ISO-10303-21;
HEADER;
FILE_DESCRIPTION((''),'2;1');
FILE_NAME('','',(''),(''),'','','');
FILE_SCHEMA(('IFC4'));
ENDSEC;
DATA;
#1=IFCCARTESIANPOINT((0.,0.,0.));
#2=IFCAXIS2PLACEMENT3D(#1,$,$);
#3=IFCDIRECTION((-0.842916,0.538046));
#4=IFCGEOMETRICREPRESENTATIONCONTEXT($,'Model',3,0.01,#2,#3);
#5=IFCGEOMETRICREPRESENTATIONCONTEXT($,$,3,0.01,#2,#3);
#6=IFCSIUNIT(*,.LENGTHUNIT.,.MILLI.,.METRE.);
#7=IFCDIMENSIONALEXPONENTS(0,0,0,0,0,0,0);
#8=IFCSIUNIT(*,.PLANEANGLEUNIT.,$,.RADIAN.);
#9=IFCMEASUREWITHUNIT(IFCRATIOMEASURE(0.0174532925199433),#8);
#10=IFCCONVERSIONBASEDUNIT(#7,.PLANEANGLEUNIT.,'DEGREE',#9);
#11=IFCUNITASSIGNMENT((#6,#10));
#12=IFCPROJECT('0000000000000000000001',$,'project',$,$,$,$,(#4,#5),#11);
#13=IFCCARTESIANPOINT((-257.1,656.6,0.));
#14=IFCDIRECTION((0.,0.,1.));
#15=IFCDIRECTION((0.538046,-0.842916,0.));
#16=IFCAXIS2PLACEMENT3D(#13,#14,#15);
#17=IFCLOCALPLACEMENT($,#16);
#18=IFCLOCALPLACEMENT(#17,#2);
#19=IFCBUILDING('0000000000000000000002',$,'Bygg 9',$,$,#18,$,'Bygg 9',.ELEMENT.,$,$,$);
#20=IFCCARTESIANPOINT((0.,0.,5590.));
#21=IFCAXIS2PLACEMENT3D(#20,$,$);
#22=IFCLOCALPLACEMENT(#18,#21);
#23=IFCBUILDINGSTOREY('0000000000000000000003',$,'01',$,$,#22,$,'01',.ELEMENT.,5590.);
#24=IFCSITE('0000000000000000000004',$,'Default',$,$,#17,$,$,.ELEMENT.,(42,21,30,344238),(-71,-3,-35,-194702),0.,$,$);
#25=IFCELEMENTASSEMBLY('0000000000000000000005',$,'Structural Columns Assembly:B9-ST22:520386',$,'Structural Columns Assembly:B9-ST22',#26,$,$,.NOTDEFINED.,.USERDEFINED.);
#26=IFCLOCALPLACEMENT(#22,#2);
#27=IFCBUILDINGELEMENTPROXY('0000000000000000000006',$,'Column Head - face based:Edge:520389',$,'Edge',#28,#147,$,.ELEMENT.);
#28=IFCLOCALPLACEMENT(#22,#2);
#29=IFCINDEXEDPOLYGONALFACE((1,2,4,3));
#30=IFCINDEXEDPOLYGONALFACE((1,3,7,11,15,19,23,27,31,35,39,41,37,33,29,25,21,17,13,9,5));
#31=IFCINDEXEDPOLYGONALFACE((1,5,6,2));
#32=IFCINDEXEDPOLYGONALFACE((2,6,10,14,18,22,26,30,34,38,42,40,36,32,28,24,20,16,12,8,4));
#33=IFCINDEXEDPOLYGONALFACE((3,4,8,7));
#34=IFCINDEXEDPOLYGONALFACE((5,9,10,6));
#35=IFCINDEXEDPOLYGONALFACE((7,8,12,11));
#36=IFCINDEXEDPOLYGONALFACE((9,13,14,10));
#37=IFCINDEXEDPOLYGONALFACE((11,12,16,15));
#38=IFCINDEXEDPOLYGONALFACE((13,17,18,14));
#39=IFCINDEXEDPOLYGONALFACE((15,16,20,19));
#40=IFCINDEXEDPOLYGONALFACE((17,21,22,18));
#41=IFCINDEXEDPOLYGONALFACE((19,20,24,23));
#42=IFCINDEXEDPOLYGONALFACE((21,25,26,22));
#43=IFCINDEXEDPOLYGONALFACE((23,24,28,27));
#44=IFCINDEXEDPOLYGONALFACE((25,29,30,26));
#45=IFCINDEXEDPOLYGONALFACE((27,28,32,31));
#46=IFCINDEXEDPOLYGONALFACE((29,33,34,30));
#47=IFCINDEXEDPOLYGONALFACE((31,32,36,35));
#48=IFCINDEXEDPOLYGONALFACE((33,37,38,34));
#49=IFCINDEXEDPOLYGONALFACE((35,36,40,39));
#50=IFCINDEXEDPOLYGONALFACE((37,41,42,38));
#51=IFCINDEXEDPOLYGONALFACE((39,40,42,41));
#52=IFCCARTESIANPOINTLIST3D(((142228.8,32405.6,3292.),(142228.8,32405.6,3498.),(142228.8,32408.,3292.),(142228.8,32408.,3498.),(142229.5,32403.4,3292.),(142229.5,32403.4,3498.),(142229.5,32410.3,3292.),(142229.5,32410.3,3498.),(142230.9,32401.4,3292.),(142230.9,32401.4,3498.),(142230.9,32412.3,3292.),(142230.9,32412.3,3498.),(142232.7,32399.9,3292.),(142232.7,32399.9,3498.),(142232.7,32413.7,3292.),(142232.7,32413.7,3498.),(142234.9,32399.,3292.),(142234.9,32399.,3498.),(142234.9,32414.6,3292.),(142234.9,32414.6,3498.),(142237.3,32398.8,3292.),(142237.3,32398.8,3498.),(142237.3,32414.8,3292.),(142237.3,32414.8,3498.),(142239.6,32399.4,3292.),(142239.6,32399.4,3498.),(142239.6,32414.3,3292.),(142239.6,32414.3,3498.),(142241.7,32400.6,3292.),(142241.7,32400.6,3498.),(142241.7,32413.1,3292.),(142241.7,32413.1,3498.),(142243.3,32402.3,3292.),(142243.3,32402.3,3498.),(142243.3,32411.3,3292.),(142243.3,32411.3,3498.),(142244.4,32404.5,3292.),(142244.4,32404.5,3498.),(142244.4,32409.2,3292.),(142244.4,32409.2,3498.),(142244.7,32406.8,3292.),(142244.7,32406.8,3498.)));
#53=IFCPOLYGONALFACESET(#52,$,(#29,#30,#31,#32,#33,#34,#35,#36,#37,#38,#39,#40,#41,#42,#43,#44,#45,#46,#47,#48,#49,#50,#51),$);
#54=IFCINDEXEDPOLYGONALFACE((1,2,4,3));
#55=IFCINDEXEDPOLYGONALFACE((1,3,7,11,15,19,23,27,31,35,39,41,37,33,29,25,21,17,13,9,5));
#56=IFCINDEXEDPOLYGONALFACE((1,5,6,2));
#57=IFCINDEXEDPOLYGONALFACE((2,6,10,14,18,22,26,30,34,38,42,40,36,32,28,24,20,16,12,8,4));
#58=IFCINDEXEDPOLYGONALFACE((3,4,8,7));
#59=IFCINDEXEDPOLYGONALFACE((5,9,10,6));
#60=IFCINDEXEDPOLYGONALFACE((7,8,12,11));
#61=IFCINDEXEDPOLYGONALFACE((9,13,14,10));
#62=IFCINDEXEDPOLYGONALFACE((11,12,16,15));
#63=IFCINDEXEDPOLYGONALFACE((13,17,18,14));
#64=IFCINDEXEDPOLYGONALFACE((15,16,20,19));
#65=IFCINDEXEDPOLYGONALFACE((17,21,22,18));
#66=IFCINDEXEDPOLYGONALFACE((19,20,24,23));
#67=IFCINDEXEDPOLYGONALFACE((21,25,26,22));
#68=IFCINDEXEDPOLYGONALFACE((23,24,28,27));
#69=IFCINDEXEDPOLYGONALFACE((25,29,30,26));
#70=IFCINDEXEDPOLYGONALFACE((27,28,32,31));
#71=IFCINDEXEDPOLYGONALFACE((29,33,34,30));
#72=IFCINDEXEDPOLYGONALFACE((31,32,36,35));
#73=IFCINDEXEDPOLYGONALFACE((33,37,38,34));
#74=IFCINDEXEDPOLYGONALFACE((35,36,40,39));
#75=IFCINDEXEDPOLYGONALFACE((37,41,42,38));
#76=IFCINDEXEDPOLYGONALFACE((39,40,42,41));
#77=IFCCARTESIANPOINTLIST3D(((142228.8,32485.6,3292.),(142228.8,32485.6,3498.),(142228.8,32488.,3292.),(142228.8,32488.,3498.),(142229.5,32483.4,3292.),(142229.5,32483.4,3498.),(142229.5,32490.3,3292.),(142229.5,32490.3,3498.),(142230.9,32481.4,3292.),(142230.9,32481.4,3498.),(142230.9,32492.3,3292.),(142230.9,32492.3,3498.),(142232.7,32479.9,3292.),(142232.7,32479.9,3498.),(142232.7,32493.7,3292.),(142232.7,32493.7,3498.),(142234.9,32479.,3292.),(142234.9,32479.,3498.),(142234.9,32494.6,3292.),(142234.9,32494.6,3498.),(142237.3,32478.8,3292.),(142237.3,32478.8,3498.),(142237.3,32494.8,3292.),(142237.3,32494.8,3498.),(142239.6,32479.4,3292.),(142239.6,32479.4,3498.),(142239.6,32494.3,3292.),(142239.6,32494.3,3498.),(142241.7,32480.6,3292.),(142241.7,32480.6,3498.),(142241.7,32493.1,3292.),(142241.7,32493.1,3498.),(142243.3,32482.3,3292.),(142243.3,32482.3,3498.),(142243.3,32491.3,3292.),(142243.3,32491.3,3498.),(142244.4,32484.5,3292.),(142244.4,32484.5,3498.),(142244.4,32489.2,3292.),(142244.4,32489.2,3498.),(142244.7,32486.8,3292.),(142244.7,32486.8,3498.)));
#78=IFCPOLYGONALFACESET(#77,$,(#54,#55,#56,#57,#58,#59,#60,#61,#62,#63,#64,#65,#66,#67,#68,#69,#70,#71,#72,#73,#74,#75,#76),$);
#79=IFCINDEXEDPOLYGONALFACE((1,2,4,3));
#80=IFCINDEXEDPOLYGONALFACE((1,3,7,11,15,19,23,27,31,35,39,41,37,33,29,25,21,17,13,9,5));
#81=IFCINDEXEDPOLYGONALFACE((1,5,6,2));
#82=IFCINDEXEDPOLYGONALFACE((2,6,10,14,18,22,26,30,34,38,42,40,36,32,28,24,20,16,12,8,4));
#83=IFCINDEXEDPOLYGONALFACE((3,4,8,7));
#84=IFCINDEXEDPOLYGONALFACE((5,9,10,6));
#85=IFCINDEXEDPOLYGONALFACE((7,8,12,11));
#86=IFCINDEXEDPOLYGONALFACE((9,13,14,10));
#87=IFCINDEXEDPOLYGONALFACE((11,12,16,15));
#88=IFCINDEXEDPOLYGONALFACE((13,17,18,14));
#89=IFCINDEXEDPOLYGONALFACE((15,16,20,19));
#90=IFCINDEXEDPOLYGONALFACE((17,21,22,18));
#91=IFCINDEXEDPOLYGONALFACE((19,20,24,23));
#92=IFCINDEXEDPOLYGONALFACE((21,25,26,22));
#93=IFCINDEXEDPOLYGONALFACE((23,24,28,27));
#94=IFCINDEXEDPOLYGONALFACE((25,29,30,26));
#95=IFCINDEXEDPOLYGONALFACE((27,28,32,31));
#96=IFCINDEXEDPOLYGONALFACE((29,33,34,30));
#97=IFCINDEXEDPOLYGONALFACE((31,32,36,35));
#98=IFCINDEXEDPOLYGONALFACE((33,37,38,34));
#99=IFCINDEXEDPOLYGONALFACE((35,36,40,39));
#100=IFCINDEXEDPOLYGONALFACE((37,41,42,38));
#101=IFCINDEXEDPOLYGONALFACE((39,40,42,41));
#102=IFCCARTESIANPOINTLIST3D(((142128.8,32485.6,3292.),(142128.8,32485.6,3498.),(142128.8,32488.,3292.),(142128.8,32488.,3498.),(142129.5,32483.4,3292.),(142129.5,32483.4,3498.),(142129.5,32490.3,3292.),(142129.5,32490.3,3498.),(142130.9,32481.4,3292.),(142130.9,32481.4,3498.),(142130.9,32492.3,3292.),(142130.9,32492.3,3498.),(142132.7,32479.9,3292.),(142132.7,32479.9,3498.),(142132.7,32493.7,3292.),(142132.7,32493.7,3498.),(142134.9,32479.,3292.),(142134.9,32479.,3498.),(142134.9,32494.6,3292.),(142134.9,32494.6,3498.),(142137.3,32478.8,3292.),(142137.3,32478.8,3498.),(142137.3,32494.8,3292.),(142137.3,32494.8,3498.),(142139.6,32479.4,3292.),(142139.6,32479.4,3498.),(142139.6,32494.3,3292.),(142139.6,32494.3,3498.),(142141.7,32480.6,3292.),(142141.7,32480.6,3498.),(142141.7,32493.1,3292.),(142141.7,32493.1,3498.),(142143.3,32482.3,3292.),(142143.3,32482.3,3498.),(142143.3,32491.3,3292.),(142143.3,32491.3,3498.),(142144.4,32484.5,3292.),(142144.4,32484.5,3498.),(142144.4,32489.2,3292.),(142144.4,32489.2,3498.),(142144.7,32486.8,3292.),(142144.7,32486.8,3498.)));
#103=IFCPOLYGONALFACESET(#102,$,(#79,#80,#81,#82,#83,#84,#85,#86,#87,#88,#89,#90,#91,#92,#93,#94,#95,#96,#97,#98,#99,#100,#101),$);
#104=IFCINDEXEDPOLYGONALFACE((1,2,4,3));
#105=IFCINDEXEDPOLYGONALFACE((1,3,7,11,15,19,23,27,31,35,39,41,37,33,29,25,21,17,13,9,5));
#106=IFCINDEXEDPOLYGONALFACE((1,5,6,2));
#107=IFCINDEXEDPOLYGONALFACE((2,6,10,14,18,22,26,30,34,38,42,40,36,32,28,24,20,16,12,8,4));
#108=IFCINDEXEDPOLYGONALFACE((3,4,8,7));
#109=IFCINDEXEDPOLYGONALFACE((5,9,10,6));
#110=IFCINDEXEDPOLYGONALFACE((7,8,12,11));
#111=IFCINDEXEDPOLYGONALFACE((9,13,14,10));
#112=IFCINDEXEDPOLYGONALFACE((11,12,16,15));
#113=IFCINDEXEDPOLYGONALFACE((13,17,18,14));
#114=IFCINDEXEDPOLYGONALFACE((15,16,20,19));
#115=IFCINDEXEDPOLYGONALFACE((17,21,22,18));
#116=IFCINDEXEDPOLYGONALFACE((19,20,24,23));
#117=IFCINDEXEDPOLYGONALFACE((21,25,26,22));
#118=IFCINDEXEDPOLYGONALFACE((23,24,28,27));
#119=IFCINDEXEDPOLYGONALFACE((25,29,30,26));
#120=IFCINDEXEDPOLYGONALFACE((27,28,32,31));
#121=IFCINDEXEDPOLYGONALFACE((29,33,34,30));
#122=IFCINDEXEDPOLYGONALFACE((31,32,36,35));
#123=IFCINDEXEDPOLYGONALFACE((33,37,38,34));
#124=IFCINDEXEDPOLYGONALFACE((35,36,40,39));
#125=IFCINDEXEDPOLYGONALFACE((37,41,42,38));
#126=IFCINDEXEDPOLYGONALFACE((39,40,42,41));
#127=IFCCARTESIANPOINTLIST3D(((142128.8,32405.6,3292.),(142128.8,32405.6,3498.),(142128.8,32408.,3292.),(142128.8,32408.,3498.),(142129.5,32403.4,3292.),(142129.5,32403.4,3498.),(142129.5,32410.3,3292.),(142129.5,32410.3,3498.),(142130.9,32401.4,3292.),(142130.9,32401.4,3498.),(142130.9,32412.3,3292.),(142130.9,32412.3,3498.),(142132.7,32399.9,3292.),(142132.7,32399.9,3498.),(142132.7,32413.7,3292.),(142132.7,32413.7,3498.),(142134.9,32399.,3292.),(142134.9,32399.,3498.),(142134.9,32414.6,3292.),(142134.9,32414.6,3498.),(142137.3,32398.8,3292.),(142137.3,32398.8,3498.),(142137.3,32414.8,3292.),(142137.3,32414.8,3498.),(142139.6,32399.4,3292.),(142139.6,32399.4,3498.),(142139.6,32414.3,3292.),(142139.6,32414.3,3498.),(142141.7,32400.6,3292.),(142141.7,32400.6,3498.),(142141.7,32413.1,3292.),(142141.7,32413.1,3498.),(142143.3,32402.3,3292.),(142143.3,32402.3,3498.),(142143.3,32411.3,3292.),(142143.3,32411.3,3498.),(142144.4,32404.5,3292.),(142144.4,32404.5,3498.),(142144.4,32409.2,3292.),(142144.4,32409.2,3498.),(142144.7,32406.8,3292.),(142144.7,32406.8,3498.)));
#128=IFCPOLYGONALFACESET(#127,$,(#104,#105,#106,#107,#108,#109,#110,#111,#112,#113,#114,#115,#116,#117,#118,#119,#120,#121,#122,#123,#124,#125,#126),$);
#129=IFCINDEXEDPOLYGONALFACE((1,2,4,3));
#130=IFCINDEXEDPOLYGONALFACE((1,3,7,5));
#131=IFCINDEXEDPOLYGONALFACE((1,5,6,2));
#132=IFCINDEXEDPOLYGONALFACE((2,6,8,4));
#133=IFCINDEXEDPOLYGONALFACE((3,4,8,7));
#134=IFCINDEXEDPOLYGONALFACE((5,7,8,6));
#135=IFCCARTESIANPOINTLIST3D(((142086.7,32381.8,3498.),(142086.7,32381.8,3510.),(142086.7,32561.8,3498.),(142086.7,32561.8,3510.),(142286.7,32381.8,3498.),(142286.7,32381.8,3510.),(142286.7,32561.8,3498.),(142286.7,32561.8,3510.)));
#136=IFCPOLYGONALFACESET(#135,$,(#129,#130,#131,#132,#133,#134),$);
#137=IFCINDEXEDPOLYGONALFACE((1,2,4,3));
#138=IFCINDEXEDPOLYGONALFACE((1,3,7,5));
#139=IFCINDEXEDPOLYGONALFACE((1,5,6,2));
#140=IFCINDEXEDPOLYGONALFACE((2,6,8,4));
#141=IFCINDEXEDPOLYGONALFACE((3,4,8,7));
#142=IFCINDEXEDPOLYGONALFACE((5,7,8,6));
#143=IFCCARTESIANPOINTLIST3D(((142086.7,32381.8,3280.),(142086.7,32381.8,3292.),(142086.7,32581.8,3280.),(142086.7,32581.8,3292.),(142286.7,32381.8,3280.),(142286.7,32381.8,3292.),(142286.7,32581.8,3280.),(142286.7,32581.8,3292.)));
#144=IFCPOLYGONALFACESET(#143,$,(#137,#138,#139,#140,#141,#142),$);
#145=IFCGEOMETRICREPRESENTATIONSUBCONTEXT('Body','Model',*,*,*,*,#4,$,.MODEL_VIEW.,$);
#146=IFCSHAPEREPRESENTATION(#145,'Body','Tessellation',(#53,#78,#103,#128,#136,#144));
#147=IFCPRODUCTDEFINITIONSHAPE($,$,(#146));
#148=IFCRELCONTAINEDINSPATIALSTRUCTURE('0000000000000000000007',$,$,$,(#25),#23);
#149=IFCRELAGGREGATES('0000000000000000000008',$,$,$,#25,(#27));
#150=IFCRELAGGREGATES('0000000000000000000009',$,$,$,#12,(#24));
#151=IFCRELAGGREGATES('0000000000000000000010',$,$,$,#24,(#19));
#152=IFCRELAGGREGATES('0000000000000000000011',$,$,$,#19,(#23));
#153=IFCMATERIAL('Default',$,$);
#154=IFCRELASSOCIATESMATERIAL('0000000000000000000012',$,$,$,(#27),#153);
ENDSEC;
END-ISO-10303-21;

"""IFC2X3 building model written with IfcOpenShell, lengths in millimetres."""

from ifc_helpers import new_model, entity, si_unit, converted_unit, direction, frame, frame_2d, origin, origin_2d_with_axis, place, context, subcontext, project, spatial, rectangle, circle, extrude, source, transform, mapped, material, element, aggregate, save


model = new_model("IFC2X3")

# Units and contexts
model_context = context("Model", 3, precision=0.01, world=origin(), true_north=direction((-0.842916, 0.538046)))
context_of_model = context(None, 3, precision=0.01, world=origin(), true_north=direction((-0.842916, 0.538046)))
body_context = subcontext(model_context, "Body", "Model", "MODEL_VIEW")
ifc_project = project(units=[si_unit("LENGTHUNIT", "METRE", prefix="MILLI"), converted_unit("PLANEANGLEUNIT", "DEGREE", entity("IfcRatioMeasure", 0.0174532925199433), si_unit("PLANEANGLEUNIT", "RADIAN"), dimensions=[0, 0, 0, 0, 0, 0, 0])], contexts=[model_context, context_of_model])

# Site, building, storey
site_placement = place(None, frame((-257.1, 656.6, 0.0), z_axis=(0.0, 0.0, 1.0), x_axis=(0.538046, -0.842916, 0.0)))
site = spatial("IfcSite", under=ifc_project, at=site_placement, Name="Default", CompositionType="ELEMENT", RefLatitude=(42, 21, 30, 344238), RefLongitude=(-71, -3, -35, -194702), RefElevation=0.0)
building_placement = place(site_placement, origin())
building = spatial("IfcBuilding", under=site, at=building_placement, Name="Bygg 9", LongName="Bygg 9", CompositionType="ELEMENT")
storey_placement = place(building_placement, frame((0.0, 0.0, 5590.0)))
storey = spatial("IfcBuildingStorey", under=building, at=storey_placement, Name="01", LongName="01", CompositionType="ELEMENT", Elevation=5590.0)

# Element assembly, building element proxy
assembly_1_placement = place(storey_placement, origin())
assembly_1 = element("IfcElementAssembly", 1, at=assembly_1_placement, inside=storey, Name="Structural Columns Assembly:B9-ST22:520386", ObjectType="Structural Columns Assembly:B9-ST22", AssemblyPlace="NOTDEFINED", PredefinedType="USERDEFINED")
ifc_material_1 = material(Name="Default")
shared_shape_1 = source(origin(), body_context, "Body", "SweptSolid", [
    extrude(circle(Radius=8.0, at=frame_2d((0.0, 0.0), x_axis=(1.0, 0.0))), frame((50.0, -135.0, 12.0)), (0.0, 0.0, 1.0), 206.0),
    extrude(circle(Radius=8.0, at=frame_2d((0.0, 0.0), x_axis=(1.0, 0.0))), frame((50.0, -55.0, 12.0)), (0.0, 0.0, 1.0), 206.0),
    extrude(circle(Radius=8.0, at=frame_2d((0.0, 0.0), x_axis=(1.0, 0.0))), frame((-50.0, -55.0, 12.0)), (0.0, 0.0, 1.0), 206.0),
    extrude(circle(Radius=8.0, at=frame_2d((0.0, 0.0), x_axis=(1.0, 0.0))), frame((-50.0, -135.0, 12.0)), (0.0, 0.0, 1.0), 206.0),
    extrude(rectangle(XDim=200.0, YDim=180.0, at=origin_2d_with_axis()), frame((0.0, -70.0, 218.0), z_axis=(0.0, 0.0, 1.0), x_axis=(-1.0, 0.0, 0.0)), (0.0, 0.0, 1.0), 12.0),
    extrude(rectangle(XDim=200.0, YDim=200.0, at=origin_2d_with_axis()), frame((0.0, -60.0, 0.0), z_axis=(0.0, 0.0, 1.0), x_axis=(0.0, 1.0, 0.0)), (0.0, 0.0, 1.0), 12.0),
])
proxy_1_placement = place(assembly_1_placement, frame((142186.7, 32541.8, 3280.0)))
proxy_1 = element("IfcBuildingElementProxy", 2, at=proxy_1_placement, material=ifc_material_1, Name="Column Head - face based:Edge:520389", ObjectType="Edge", CompositionType="ELEMENT", context=body_context, shape_type="MappedRepresentation", body=[
    mapped(shared_shape_1, transform((0.0, 0.0, 0.0), scale=1.0)),
])
aggregate(assembly_1, [proxy_1])

save(model, "model.ifc")
